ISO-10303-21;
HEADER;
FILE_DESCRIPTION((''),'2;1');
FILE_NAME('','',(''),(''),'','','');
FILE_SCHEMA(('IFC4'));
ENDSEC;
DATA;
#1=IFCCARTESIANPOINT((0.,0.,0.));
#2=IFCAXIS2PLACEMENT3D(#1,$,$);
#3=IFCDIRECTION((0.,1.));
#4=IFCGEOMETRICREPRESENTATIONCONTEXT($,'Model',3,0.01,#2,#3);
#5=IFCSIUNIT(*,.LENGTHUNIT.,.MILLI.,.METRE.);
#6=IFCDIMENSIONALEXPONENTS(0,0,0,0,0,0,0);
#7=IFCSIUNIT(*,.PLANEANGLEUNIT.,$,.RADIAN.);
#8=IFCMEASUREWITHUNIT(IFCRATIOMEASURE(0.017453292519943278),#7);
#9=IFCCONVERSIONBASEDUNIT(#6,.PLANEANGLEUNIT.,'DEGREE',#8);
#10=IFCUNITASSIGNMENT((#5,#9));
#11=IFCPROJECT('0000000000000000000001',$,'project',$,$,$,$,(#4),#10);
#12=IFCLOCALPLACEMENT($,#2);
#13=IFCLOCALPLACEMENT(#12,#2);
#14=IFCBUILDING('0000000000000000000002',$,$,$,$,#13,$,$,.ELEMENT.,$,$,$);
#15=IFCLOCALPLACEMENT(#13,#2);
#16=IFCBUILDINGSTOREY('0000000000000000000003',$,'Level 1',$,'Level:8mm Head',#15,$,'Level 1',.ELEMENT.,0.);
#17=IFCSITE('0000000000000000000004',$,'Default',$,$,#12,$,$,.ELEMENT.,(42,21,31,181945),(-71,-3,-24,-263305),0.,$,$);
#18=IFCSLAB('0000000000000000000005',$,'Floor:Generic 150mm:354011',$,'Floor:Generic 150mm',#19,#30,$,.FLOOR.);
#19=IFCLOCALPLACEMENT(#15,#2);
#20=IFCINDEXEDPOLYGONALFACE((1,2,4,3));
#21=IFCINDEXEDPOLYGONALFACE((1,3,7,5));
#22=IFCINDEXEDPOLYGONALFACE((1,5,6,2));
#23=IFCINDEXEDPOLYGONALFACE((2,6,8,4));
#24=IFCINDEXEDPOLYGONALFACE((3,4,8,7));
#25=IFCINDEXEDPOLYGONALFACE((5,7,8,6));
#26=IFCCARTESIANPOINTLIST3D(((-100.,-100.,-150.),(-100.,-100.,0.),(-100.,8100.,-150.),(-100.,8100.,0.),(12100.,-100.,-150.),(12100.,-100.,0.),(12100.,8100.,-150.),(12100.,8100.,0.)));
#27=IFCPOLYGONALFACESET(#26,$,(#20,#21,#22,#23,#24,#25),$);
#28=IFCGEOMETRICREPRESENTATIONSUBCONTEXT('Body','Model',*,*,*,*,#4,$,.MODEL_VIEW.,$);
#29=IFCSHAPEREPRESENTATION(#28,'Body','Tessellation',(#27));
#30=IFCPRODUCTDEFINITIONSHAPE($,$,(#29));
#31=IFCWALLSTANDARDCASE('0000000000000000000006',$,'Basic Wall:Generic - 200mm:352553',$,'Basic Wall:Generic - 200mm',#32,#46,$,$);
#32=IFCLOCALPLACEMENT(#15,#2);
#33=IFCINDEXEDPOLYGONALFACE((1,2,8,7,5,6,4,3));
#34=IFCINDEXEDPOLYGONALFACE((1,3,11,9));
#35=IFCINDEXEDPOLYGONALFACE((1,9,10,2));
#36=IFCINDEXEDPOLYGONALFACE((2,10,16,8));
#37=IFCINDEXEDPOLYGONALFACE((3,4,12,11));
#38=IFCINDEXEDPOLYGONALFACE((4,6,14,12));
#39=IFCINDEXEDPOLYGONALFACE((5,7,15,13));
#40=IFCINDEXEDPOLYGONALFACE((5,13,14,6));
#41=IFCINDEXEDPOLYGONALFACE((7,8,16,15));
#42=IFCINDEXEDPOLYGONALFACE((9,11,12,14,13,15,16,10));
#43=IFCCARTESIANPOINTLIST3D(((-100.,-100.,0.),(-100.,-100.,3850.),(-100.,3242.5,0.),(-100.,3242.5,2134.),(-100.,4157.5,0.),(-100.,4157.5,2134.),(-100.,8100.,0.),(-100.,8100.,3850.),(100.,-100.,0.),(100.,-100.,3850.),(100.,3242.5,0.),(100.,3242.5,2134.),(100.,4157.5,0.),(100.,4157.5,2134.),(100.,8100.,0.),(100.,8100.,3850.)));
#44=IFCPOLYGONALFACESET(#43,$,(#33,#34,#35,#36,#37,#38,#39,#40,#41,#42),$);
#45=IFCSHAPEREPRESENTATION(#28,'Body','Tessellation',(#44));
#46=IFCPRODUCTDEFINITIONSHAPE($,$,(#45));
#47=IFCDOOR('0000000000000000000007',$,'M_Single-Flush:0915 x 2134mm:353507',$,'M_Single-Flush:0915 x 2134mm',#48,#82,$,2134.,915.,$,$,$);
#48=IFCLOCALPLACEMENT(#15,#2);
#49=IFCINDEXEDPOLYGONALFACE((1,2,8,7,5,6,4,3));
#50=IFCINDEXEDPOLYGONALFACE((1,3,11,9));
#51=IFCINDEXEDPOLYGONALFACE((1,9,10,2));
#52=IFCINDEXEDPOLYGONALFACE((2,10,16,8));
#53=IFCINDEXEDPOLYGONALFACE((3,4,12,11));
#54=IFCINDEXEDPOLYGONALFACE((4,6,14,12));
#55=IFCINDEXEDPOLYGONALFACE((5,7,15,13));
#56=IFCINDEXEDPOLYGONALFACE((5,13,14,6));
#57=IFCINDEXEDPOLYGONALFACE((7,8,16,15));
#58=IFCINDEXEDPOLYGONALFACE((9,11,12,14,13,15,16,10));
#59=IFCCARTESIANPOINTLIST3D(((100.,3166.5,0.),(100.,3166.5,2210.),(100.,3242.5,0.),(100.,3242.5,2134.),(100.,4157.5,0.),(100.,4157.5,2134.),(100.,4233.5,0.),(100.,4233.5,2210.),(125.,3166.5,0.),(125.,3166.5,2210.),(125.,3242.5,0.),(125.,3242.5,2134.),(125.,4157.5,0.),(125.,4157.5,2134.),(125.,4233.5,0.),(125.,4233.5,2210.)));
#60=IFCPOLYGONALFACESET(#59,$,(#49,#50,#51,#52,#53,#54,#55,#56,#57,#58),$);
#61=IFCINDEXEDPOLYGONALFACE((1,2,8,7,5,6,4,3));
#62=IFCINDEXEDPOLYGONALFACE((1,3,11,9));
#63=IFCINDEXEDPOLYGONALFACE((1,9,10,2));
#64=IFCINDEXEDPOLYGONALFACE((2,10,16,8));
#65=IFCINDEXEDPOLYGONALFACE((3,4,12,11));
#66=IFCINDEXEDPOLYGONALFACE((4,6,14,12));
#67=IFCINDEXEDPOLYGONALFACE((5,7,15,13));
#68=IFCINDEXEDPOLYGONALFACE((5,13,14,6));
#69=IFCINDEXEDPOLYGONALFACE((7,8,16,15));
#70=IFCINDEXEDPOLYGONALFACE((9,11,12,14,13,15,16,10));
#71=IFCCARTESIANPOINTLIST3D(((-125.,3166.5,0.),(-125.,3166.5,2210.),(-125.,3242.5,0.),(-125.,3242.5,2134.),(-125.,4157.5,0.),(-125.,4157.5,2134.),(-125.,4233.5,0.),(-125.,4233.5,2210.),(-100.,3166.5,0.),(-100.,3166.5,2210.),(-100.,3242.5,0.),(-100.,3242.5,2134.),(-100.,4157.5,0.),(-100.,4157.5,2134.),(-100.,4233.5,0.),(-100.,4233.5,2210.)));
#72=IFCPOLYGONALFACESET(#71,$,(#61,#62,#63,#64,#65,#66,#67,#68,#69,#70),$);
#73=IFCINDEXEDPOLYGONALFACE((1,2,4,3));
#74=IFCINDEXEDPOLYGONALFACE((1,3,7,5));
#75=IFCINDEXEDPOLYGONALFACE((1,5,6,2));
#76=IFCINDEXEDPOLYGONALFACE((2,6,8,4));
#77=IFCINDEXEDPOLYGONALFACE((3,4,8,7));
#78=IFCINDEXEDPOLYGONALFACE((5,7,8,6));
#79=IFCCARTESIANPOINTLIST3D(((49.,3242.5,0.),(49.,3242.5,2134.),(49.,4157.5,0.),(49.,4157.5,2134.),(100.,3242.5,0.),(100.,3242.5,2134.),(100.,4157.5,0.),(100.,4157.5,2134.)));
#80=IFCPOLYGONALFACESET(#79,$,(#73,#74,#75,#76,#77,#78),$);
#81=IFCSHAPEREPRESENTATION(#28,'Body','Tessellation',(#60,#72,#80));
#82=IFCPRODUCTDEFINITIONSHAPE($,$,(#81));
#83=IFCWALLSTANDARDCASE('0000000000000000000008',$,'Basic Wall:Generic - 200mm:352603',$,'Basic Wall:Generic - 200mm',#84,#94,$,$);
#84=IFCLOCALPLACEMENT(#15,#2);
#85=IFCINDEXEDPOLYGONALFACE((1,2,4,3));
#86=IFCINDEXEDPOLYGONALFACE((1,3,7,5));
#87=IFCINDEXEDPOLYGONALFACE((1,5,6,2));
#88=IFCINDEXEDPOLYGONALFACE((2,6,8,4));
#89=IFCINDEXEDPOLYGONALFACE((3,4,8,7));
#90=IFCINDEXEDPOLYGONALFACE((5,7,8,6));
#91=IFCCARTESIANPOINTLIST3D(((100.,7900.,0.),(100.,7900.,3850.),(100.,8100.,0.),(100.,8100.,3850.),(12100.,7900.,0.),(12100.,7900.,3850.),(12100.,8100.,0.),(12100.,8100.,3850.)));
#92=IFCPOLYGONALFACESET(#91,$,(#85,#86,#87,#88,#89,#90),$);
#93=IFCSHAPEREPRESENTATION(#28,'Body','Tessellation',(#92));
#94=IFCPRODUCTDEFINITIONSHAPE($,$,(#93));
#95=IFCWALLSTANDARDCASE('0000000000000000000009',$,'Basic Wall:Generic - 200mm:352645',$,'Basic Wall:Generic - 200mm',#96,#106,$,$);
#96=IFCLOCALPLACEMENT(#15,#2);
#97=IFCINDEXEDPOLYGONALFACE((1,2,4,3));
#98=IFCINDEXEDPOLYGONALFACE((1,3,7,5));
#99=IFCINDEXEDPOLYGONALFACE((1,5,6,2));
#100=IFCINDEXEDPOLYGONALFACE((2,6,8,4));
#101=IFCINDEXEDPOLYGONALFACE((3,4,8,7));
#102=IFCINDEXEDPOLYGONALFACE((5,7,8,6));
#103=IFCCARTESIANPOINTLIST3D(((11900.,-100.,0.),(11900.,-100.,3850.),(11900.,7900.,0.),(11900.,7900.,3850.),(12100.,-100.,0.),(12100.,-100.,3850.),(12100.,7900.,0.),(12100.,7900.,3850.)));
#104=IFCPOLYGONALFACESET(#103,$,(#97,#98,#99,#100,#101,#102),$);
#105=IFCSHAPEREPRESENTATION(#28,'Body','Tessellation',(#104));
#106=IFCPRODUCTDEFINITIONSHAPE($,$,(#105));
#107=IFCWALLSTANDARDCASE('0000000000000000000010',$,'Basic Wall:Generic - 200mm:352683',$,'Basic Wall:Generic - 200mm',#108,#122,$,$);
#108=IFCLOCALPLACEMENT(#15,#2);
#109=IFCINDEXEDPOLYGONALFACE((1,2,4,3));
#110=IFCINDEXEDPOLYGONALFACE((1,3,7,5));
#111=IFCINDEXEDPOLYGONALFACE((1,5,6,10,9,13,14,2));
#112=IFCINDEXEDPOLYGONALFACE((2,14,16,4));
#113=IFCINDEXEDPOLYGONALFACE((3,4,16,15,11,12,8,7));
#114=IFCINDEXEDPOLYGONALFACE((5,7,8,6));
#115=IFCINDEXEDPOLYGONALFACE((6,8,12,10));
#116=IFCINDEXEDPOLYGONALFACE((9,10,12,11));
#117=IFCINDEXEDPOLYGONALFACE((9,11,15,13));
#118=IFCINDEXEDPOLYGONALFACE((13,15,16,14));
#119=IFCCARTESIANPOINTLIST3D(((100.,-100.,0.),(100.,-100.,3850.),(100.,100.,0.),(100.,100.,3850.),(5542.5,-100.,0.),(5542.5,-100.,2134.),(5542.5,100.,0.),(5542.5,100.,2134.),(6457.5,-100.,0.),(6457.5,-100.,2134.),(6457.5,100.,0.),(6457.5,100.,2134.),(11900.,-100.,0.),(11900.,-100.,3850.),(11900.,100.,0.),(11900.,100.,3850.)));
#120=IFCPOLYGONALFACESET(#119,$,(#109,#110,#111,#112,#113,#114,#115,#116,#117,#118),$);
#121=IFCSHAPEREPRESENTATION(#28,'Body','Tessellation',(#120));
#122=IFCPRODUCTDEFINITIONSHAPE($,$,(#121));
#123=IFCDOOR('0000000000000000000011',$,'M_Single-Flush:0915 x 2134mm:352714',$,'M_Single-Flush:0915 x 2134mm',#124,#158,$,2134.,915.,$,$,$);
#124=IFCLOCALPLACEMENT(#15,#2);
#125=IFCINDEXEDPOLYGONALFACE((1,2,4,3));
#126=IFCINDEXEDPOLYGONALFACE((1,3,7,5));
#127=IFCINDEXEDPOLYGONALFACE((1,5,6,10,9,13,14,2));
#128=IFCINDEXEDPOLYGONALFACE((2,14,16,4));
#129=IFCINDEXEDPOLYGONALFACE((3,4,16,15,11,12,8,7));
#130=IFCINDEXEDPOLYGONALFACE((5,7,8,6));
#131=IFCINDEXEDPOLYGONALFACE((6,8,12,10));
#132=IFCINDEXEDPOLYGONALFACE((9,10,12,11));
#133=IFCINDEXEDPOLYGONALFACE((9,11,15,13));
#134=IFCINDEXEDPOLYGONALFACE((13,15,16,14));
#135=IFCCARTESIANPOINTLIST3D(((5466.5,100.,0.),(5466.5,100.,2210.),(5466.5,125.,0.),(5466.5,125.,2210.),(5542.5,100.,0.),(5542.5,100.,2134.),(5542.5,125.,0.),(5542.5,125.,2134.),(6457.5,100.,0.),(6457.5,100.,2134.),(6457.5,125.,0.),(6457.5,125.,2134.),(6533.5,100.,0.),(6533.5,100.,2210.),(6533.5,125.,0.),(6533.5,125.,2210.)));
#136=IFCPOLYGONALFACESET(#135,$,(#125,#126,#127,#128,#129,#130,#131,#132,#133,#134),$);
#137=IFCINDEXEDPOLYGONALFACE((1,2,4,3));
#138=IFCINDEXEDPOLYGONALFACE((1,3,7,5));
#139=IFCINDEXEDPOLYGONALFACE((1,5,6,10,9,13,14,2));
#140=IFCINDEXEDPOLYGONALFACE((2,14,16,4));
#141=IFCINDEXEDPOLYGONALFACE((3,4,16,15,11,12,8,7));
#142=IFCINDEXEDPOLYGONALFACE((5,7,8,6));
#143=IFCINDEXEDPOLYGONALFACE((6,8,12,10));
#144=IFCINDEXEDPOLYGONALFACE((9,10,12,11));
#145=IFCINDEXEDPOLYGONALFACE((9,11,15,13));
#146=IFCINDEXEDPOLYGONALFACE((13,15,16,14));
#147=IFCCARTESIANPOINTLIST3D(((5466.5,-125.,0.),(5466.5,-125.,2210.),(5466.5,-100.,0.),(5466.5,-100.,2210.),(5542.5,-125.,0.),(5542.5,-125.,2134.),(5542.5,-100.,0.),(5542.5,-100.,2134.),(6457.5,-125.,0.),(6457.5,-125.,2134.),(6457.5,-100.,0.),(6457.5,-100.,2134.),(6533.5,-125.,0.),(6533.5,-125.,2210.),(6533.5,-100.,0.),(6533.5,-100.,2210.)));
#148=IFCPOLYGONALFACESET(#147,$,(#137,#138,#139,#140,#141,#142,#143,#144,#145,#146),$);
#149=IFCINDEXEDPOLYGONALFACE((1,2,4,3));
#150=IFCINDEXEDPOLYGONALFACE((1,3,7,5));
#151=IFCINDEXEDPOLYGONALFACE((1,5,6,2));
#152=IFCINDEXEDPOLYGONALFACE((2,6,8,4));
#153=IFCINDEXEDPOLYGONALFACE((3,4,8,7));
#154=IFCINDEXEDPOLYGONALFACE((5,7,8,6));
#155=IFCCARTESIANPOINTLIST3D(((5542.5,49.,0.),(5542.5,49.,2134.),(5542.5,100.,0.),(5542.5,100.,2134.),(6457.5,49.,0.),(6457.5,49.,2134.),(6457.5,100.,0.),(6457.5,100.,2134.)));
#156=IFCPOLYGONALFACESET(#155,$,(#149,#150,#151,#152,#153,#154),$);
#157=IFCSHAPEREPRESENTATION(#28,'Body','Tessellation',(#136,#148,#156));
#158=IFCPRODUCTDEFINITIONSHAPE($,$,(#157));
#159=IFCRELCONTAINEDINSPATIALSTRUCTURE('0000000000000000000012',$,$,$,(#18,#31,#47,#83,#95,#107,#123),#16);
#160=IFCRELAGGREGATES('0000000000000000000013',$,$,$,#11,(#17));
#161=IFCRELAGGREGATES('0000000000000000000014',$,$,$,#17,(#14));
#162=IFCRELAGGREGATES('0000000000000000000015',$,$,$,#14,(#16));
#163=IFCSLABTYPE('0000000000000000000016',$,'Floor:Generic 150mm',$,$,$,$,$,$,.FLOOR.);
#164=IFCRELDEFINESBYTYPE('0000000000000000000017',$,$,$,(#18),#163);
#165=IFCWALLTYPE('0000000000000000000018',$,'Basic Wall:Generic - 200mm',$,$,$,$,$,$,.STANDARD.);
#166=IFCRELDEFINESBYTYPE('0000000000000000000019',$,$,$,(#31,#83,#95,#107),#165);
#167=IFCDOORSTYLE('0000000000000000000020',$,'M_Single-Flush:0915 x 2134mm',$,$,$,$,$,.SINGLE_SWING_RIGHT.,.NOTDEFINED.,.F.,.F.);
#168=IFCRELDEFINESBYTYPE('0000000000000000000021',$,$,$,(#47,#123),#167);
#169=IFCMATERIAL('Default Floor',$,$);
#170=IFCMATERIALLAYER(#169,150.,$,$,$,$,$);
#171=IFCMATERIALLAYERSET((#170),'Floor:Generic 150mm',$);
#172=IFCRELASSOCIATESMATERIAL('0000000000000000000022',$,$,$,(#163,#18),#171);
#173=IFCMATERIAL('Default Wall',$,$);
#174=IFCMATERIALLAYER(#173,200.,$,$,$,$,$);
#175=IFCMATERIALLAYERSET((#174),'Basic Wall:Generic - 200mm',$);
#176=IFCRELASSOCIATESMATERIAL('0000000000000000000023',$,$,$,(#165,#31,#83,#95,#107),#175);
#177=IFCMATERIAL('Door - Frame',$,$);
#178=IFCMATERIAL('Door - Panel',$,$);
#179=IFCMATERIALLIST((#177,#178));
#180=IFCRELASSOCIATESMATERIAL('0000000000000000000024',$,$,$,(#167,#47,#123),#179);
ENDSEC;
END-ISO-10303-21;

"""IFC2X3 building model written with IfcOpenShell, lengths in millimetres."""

from ifc_helpers import new_model, entity, si_unit, converted_unit, direction, frame, frame_2d, origin, place, context, subcontext, project, spatial, polyline, rectangle, outline, extrude, clip, bounded_halfspace, source, transform, mapped, material, material_list, layer, layer_set, layer_usage, type_object, type_shapes, element, fill, save


model = new_model("IFC2X3")

# Units and contexts
model_context = context("Model", 3, precision=0.01, world=origin(), true_north=direction((0.0, 1.0)))
body_context = subcontext(model_context, "Body", "Model", "MODEL_VIEW")
ifc_project = project(units=[si_unit("LENGTHUNIT", "METRE", prefix="MILLI"), converted_unit("PLANEANGLEUNIT", "DEGREE", entity("IfcRatioMeasure", 0.017453292519943278), si_unit("PLANEANGLEUNIT", "RADIAN"), dimensions=[0, 0, 0, 0, 0, 0, 0])], contexts=[model_context])

# Site, building, storey
site_placement = place(None, origin())
site = spatial("IfcSite", under=ifc_project, at=site_placement, Name="Default", CompositionType="ELEMENT", RefLatitude=(42, 21, 31, 181945), RefLongitude=(-71, -3, -24, -263305), RefElevation=0.0)
building_placement = place(site_placement, origin())
building = spatial("IfcBuilding", under=site, at=building_placement, CompositionType="ELEMENT")
storey_placement = place(building_placement, origin())
storey = spatial("IfcBuildingStorey", under=building, at=storey_placement, Name="Level 1", ObjectType="Level:8mm Head", LongName="Level 1", CompositionType="ELEMENT", Elevation=0.0)

# Slab
ifc_material_1 = material(Name="Default Floor")
ifc_layer_1 = layer(ifc_material_1, 150.0)
ifc_layer_set_1 = layer_set([ifc_layer_1], Name="Floor:Generic 150mm")
ifc_layer_usage_1 = layer_usage(ifc_layer_set_1, "AXIS3", "POSITIVE", 0.0)
slab_type = type_object("IfcSlabType", Name="Floor:Generic 150mm", PredefinedType="FLOOR", material=ifc_layer_set_1)
slab_placement = place(storey_placement, origin())
element("IfcSlab", 1, at=slab_placement, inside=storey, type_object=slab_type, material=ifc_layer_usage_1, Name="Floor:Generic 150mm:354011", ObjectType="Floor:Generic 150mm", PredefinedType="FLOOR", context=body_context, shape_type="SweptSolid", body=[
    extrude(rectangle(XDim=8200.0, YDim=12200.0, at=frame_2d((0.0, 0.0), x_axis=(1.0, 0.0))), frame((6000.0, 4000.0, 0.0), z_axis=(0.0, 0.0, -1.0), x_axis=(0.0, 1.0, 0.0)), (0.0, 0.0, 1.0), 150.0),
])

# Wall, opening, door
ifc_material_2 = material(Name="Default Wall")
ifc_layer_2 = layer(ifc_material_2, 200.0)
ifc_layer_set_2 = layer_set([ifc_layer_2], Name="Basic Wall:Generic - 200mm")
ifc_layer_usage_2 = layer_usage(ifc_layer_set_2, "AXIS2", "NEGATIVE", 100.0)
wall_type = type_object("IfcWallType", Name="Basic Wall:Generic - 200mm", PredefinedType="STANDARD", material=ifc_layer_set_2)
wall_1_placement = place(storey_placement, frame((0.0, -100.0, 0.0), z_axis=(0.0, 0.0, 1.0), x_axis=(0.0, 1.0, 0.0)))
wall_1 = element("IfcWallStandardCase", 2, at=wall_1_placement, inside=storey, type_object=wall_type, material=ifc_layer_usage_2, Name="Basic Wall:Generic - 200mm:352553", ObjectType="Basic Wall:Generic - 200mm", context=body_context, shape_type="Clipping", body=[
    clip(extrude(rectangle(XDim=8200.0, YDim=200.0, at=frame_2d((4100.0, 0.0), x_axis=(-1.0, 0.0))), origin(), (0.0, 0.0, 1.0), 3850.0), bounded_halfspace(frame((0.0, -100.0, 3850.0), z_axis=(0.0, 0.0, -1.0), x_axis=(-1.0, 0.0, 0.0)), True, frame((0.0, -100.0, 3850.0)), polyline([(0.0, 0.0), (200.0, 0.0), (2800.0, 0.0), (3000.0, 0.0), (4600.0, 0.0), (4800.0, 0.0), (8000.0, 0.0), (8200.0, 0.0), (8200.0, 200.0), (0.0, 200.0), (0.0, 0.0)]))),
])
opening_1_placement = place(wall_1_placement, frame((4257.5, 100.0, 0.0)))
opening_1 = element("IfcOpeningElement", 3, at=opening_1_placement, cuts=wall_1, ObjectType="Opening", context=body_context, shape_type="SweptSolid", body=[
    extrude(rectangle(XDim=915.0, YDim=2134.0, at=frame_2d((1067.0, 457.5), x_axis=(0.0, 1.0))), frame((0.0, 0.0, 0.0), z_axis=(0.0, -1.0, 0.0), x_axis=(0.0, 0.0, 1.0)), (0.0, 0.0, 1.0), 200.0),
])
ifc_material_3 = material(Name="Door - Frame")
ifc_material_4 = material(Name="Door - Panel")
ifc_material_list = material_list([ifc_material_3, ifc_material_4])
door_style = type_object("IfcDoorStyle", Name="M_Single-Flush:0915 x 2134mm", ConstructionType="NOTDEFINED", OperationType="SINGLE_SWING_RIGHT", ParameterTakesPrecedence=False, Sizeable=False, material=ifc_material_list)
shared_shape = source(origin(), body_context, "Body", "SweptSolid", [
    extrude(outline(polyline([(-533.5, -1124.0), (533.5, -1124.0), (533.5, 1086.0), (457.5, 1086.0), (457.5, -1048.0), (-457.5, -1048.0), (-457.5, 1086.0), (-533.5, 1086.0), (-533.5, -1124.0)])), frame((457.5, 200.0, 1086.0), z_axis=(0.0, 1.0, 0.0), x_axis=(1.0, 0.0, 0.0)), (0.0, 0.0, 1.0), 25.0),
    extrude(outline(polyline([(-1124.0, -533.5), (1086.0, -533.5), (1086.0, -457.5), (-1048.0, -457.5), (-1048.0, 457.5), (1086.0, 457.5), (1086.0, 533.5), (-1124.0, 533.5), (-1124.0, -533.5)])), frame((457.5, -25.0, 1086.0), z_axis=(0.0, 1.0, 0.0), x_axis=(0.0, 0.0, -1.0)), (0.0, 0.0, 1.0), 25.0),
    extrude(rectangle(XDim=51.0, YDim=915.0, at=frame_2d((0.0, 0.0), x_axis=(1.0, 0.0))), frame((457.5, 174.5, 0.0), z_axis=(0.0, 0.0, 1.0), x_axis=(0.0, 1.0, 0.0)), (0.0, 0.0, 1.0), 2134.0),
])
type_shapes(door_style, [shared_shape])
door_1_placement = place(opening_1_placement, frame((0.0, 0.0, 0.0), z_axis=(0.0, 0.0, 1.0), x_axis=(-1.0, 0.0, 0.0)))
door_1 = element("IfcDoor", 4, at=door_1_placement, inside=storey, type_object=door_style, material=ifc_material_list, Name="M_Single-Flush:0915 x 2134mm:353507", ObjectType="M_Single-Flush:0915 x 2134mm", OverallHeight=2134.0, OverallWidth=915.0, context=body_context, shape_type="MappedRepresentation", body=[
    mapped(shared_shape, transform((0.0, 0.0, 0.0), scale=1.0)),
])
fill(opening_1, door_1)

# Walls
wall_2_placement = place(storey_placement, frame((100.0, 8000.0, 0.0)))
element("IfcWallStandardCase", 5, at=wall_2_placement, inside=storey, type_object=wall_type, material=ifc_layer_usage_2, Name="Basic Wall:Generic - 200mm:352603", ObjectType="Basic Wall:Generic - 200mm", context=body_context, shape_type="Clipping", body=[
    clip(extrude(rectangle(XDim=12000.0, YDim=200.0, at=frame_2d((6000.0, 0.0), x_axis=(-1.0, 0.0))), origin(), (0.0, 0.0, 1.0), 3850.0), bounded_halfspace(frame((0.0, -100.0, 3850.0), z_axis=(0.0, 0.0, -1.0), x_axis=(0.0, -1.0, 0.0)), True, frame((0.0, -100.0, 3850.0)), polyline([(0.0, 0.0), (4800.0, 0.0), (5000.0, 0.0), (8700.0, 0.0), (8900.0, 0.0), (11800.0, 0.0), (12000.0, 0.0), (12000.0, 200.0), (0.0, 200.0), (0.0, 0.0)]))),
])
wall_3_placement = place(storey_placement, frame((12000.0, 7900.0, 0.0), z_axis=(0.0, 0.0, 1.0), x_axis=(0.0, -1.0, 0.0)))
element("IfcWallStandardCase", 6, at=wall_3_placement, inside=storey, type_object=wall_type, material=ifc_layer_usage_2, Name="Basic Wall:Generic - 200mm:352645", ObjectType="Basic Wall:Generic - 200mm", context=body_context, shape_type="Clipping", body=[
    clip(extrude(rectangle(XDim=8000.0, YDim=200.0, at=frame_2d((4000.0, 0.0), x_axis=(-1.0, 0.0))), origin(), (0.0, 0.0, 1.0), 3850.0), bounded_halfspace(frame((0.0, -100.0, 3850.0), z_axis=(0.0, 0.0, -1.0), x_axis=(1.0, 0.0, 0.0)), True, frame((0.0, -100.0, 3850.0)), polyline([(0.0, 0.0), (3300.0, 0.0), (7800.0, 0.0), (8000.0, 0.0), (8000.0, 200.0), (0.0, 200.0), (0.0, 0.0)]))),
])

# Wall, opening, door
wall_4_placement = place(storey_placement, frame((11900.0, 0.0, 0.0), z_axis=(0.0, 0.0, 1.0), x_axis=(-1.0, 0.0, 0.0)))
wall_4 = element("IfcWallStandardCase", 7, at=wall_4_placement, inside=storey, type_object=wall_type, material=ifc_layer_usage_2, Name="Basic Wall:Generic - 200mm:352683", ObjectType="Basic Wall:Generic - 200mm", context=body_context, shape_type="Clipping", body=[
    clip(extrude(rectangle(XDim=11800.0, YDim=200.0, at=frame_2d((5900.0, 0.0), x_axis=(1.0, 0.0))), origin(), (0.0, 0.0, 1.0), 3850.0), bounded_halfspace(frame((0.0, -100.0, 3850.0), z_axis=(0.0, 0.0, -1.0), x_axis=(0.0, 1.0, 0.0)), True, frame((0.0, -100.0, 3850.0)), polyline([(0.0, 0.0), (8900.0, 0.0), (9100.0, 0.0), (11800.0, 0.0), (11800.0, 200.0), (0.0, 200.0), (0.0, 0.0)]))),
])
opening_2_placement = place(wall_4_placement, frame((6357.5, 100.0, 0.0)))
opening_2 = element("IfcOpeningElement", 8, at=opening_2_placement, cuts=wall_4, ObjectType="Opening", context=body_context, shape_type="SweptSolid", body=[
    extrude(rectangle(XDim=915.0, YDim=2134.0, at=frame_2d((1067.0, 457.5), x_axis=(0.0, 1.0))), frame((0.0, 0.0, 0.0), z_axis=(0.0, -1.0, 0.0), x_axis=(0.0, 0.0, 1.0)), (0.0, 0.0, 1.0), 200.0),
])
door_2_placement = place(opening_2_placement, frame((0.0, 0.0, 0.0), z_axis=(0.0, 0.0, 1.0), x_axis=(-1.0, 0.0, 0.0)))
door_2 = element("IfcDoor", 9, at=door_2_placement, inside=storey, type_object=door_style, material=ifc_material_list, Name="M_Single-Flush:0915 x 2134mm:352714", ObjectType="M_Single-Flush:0915 x 2134mm", OverallHeight=2134.0, OverallWidth=915.0, context=body_context, shape_type="MappedRepresentation", body=[
    mapped(shared_shape, transform((0.0, 0.0, 0.0), scale=1.0)),
])
fill(opening_2, door_2)

save(model, "model.ifc")
